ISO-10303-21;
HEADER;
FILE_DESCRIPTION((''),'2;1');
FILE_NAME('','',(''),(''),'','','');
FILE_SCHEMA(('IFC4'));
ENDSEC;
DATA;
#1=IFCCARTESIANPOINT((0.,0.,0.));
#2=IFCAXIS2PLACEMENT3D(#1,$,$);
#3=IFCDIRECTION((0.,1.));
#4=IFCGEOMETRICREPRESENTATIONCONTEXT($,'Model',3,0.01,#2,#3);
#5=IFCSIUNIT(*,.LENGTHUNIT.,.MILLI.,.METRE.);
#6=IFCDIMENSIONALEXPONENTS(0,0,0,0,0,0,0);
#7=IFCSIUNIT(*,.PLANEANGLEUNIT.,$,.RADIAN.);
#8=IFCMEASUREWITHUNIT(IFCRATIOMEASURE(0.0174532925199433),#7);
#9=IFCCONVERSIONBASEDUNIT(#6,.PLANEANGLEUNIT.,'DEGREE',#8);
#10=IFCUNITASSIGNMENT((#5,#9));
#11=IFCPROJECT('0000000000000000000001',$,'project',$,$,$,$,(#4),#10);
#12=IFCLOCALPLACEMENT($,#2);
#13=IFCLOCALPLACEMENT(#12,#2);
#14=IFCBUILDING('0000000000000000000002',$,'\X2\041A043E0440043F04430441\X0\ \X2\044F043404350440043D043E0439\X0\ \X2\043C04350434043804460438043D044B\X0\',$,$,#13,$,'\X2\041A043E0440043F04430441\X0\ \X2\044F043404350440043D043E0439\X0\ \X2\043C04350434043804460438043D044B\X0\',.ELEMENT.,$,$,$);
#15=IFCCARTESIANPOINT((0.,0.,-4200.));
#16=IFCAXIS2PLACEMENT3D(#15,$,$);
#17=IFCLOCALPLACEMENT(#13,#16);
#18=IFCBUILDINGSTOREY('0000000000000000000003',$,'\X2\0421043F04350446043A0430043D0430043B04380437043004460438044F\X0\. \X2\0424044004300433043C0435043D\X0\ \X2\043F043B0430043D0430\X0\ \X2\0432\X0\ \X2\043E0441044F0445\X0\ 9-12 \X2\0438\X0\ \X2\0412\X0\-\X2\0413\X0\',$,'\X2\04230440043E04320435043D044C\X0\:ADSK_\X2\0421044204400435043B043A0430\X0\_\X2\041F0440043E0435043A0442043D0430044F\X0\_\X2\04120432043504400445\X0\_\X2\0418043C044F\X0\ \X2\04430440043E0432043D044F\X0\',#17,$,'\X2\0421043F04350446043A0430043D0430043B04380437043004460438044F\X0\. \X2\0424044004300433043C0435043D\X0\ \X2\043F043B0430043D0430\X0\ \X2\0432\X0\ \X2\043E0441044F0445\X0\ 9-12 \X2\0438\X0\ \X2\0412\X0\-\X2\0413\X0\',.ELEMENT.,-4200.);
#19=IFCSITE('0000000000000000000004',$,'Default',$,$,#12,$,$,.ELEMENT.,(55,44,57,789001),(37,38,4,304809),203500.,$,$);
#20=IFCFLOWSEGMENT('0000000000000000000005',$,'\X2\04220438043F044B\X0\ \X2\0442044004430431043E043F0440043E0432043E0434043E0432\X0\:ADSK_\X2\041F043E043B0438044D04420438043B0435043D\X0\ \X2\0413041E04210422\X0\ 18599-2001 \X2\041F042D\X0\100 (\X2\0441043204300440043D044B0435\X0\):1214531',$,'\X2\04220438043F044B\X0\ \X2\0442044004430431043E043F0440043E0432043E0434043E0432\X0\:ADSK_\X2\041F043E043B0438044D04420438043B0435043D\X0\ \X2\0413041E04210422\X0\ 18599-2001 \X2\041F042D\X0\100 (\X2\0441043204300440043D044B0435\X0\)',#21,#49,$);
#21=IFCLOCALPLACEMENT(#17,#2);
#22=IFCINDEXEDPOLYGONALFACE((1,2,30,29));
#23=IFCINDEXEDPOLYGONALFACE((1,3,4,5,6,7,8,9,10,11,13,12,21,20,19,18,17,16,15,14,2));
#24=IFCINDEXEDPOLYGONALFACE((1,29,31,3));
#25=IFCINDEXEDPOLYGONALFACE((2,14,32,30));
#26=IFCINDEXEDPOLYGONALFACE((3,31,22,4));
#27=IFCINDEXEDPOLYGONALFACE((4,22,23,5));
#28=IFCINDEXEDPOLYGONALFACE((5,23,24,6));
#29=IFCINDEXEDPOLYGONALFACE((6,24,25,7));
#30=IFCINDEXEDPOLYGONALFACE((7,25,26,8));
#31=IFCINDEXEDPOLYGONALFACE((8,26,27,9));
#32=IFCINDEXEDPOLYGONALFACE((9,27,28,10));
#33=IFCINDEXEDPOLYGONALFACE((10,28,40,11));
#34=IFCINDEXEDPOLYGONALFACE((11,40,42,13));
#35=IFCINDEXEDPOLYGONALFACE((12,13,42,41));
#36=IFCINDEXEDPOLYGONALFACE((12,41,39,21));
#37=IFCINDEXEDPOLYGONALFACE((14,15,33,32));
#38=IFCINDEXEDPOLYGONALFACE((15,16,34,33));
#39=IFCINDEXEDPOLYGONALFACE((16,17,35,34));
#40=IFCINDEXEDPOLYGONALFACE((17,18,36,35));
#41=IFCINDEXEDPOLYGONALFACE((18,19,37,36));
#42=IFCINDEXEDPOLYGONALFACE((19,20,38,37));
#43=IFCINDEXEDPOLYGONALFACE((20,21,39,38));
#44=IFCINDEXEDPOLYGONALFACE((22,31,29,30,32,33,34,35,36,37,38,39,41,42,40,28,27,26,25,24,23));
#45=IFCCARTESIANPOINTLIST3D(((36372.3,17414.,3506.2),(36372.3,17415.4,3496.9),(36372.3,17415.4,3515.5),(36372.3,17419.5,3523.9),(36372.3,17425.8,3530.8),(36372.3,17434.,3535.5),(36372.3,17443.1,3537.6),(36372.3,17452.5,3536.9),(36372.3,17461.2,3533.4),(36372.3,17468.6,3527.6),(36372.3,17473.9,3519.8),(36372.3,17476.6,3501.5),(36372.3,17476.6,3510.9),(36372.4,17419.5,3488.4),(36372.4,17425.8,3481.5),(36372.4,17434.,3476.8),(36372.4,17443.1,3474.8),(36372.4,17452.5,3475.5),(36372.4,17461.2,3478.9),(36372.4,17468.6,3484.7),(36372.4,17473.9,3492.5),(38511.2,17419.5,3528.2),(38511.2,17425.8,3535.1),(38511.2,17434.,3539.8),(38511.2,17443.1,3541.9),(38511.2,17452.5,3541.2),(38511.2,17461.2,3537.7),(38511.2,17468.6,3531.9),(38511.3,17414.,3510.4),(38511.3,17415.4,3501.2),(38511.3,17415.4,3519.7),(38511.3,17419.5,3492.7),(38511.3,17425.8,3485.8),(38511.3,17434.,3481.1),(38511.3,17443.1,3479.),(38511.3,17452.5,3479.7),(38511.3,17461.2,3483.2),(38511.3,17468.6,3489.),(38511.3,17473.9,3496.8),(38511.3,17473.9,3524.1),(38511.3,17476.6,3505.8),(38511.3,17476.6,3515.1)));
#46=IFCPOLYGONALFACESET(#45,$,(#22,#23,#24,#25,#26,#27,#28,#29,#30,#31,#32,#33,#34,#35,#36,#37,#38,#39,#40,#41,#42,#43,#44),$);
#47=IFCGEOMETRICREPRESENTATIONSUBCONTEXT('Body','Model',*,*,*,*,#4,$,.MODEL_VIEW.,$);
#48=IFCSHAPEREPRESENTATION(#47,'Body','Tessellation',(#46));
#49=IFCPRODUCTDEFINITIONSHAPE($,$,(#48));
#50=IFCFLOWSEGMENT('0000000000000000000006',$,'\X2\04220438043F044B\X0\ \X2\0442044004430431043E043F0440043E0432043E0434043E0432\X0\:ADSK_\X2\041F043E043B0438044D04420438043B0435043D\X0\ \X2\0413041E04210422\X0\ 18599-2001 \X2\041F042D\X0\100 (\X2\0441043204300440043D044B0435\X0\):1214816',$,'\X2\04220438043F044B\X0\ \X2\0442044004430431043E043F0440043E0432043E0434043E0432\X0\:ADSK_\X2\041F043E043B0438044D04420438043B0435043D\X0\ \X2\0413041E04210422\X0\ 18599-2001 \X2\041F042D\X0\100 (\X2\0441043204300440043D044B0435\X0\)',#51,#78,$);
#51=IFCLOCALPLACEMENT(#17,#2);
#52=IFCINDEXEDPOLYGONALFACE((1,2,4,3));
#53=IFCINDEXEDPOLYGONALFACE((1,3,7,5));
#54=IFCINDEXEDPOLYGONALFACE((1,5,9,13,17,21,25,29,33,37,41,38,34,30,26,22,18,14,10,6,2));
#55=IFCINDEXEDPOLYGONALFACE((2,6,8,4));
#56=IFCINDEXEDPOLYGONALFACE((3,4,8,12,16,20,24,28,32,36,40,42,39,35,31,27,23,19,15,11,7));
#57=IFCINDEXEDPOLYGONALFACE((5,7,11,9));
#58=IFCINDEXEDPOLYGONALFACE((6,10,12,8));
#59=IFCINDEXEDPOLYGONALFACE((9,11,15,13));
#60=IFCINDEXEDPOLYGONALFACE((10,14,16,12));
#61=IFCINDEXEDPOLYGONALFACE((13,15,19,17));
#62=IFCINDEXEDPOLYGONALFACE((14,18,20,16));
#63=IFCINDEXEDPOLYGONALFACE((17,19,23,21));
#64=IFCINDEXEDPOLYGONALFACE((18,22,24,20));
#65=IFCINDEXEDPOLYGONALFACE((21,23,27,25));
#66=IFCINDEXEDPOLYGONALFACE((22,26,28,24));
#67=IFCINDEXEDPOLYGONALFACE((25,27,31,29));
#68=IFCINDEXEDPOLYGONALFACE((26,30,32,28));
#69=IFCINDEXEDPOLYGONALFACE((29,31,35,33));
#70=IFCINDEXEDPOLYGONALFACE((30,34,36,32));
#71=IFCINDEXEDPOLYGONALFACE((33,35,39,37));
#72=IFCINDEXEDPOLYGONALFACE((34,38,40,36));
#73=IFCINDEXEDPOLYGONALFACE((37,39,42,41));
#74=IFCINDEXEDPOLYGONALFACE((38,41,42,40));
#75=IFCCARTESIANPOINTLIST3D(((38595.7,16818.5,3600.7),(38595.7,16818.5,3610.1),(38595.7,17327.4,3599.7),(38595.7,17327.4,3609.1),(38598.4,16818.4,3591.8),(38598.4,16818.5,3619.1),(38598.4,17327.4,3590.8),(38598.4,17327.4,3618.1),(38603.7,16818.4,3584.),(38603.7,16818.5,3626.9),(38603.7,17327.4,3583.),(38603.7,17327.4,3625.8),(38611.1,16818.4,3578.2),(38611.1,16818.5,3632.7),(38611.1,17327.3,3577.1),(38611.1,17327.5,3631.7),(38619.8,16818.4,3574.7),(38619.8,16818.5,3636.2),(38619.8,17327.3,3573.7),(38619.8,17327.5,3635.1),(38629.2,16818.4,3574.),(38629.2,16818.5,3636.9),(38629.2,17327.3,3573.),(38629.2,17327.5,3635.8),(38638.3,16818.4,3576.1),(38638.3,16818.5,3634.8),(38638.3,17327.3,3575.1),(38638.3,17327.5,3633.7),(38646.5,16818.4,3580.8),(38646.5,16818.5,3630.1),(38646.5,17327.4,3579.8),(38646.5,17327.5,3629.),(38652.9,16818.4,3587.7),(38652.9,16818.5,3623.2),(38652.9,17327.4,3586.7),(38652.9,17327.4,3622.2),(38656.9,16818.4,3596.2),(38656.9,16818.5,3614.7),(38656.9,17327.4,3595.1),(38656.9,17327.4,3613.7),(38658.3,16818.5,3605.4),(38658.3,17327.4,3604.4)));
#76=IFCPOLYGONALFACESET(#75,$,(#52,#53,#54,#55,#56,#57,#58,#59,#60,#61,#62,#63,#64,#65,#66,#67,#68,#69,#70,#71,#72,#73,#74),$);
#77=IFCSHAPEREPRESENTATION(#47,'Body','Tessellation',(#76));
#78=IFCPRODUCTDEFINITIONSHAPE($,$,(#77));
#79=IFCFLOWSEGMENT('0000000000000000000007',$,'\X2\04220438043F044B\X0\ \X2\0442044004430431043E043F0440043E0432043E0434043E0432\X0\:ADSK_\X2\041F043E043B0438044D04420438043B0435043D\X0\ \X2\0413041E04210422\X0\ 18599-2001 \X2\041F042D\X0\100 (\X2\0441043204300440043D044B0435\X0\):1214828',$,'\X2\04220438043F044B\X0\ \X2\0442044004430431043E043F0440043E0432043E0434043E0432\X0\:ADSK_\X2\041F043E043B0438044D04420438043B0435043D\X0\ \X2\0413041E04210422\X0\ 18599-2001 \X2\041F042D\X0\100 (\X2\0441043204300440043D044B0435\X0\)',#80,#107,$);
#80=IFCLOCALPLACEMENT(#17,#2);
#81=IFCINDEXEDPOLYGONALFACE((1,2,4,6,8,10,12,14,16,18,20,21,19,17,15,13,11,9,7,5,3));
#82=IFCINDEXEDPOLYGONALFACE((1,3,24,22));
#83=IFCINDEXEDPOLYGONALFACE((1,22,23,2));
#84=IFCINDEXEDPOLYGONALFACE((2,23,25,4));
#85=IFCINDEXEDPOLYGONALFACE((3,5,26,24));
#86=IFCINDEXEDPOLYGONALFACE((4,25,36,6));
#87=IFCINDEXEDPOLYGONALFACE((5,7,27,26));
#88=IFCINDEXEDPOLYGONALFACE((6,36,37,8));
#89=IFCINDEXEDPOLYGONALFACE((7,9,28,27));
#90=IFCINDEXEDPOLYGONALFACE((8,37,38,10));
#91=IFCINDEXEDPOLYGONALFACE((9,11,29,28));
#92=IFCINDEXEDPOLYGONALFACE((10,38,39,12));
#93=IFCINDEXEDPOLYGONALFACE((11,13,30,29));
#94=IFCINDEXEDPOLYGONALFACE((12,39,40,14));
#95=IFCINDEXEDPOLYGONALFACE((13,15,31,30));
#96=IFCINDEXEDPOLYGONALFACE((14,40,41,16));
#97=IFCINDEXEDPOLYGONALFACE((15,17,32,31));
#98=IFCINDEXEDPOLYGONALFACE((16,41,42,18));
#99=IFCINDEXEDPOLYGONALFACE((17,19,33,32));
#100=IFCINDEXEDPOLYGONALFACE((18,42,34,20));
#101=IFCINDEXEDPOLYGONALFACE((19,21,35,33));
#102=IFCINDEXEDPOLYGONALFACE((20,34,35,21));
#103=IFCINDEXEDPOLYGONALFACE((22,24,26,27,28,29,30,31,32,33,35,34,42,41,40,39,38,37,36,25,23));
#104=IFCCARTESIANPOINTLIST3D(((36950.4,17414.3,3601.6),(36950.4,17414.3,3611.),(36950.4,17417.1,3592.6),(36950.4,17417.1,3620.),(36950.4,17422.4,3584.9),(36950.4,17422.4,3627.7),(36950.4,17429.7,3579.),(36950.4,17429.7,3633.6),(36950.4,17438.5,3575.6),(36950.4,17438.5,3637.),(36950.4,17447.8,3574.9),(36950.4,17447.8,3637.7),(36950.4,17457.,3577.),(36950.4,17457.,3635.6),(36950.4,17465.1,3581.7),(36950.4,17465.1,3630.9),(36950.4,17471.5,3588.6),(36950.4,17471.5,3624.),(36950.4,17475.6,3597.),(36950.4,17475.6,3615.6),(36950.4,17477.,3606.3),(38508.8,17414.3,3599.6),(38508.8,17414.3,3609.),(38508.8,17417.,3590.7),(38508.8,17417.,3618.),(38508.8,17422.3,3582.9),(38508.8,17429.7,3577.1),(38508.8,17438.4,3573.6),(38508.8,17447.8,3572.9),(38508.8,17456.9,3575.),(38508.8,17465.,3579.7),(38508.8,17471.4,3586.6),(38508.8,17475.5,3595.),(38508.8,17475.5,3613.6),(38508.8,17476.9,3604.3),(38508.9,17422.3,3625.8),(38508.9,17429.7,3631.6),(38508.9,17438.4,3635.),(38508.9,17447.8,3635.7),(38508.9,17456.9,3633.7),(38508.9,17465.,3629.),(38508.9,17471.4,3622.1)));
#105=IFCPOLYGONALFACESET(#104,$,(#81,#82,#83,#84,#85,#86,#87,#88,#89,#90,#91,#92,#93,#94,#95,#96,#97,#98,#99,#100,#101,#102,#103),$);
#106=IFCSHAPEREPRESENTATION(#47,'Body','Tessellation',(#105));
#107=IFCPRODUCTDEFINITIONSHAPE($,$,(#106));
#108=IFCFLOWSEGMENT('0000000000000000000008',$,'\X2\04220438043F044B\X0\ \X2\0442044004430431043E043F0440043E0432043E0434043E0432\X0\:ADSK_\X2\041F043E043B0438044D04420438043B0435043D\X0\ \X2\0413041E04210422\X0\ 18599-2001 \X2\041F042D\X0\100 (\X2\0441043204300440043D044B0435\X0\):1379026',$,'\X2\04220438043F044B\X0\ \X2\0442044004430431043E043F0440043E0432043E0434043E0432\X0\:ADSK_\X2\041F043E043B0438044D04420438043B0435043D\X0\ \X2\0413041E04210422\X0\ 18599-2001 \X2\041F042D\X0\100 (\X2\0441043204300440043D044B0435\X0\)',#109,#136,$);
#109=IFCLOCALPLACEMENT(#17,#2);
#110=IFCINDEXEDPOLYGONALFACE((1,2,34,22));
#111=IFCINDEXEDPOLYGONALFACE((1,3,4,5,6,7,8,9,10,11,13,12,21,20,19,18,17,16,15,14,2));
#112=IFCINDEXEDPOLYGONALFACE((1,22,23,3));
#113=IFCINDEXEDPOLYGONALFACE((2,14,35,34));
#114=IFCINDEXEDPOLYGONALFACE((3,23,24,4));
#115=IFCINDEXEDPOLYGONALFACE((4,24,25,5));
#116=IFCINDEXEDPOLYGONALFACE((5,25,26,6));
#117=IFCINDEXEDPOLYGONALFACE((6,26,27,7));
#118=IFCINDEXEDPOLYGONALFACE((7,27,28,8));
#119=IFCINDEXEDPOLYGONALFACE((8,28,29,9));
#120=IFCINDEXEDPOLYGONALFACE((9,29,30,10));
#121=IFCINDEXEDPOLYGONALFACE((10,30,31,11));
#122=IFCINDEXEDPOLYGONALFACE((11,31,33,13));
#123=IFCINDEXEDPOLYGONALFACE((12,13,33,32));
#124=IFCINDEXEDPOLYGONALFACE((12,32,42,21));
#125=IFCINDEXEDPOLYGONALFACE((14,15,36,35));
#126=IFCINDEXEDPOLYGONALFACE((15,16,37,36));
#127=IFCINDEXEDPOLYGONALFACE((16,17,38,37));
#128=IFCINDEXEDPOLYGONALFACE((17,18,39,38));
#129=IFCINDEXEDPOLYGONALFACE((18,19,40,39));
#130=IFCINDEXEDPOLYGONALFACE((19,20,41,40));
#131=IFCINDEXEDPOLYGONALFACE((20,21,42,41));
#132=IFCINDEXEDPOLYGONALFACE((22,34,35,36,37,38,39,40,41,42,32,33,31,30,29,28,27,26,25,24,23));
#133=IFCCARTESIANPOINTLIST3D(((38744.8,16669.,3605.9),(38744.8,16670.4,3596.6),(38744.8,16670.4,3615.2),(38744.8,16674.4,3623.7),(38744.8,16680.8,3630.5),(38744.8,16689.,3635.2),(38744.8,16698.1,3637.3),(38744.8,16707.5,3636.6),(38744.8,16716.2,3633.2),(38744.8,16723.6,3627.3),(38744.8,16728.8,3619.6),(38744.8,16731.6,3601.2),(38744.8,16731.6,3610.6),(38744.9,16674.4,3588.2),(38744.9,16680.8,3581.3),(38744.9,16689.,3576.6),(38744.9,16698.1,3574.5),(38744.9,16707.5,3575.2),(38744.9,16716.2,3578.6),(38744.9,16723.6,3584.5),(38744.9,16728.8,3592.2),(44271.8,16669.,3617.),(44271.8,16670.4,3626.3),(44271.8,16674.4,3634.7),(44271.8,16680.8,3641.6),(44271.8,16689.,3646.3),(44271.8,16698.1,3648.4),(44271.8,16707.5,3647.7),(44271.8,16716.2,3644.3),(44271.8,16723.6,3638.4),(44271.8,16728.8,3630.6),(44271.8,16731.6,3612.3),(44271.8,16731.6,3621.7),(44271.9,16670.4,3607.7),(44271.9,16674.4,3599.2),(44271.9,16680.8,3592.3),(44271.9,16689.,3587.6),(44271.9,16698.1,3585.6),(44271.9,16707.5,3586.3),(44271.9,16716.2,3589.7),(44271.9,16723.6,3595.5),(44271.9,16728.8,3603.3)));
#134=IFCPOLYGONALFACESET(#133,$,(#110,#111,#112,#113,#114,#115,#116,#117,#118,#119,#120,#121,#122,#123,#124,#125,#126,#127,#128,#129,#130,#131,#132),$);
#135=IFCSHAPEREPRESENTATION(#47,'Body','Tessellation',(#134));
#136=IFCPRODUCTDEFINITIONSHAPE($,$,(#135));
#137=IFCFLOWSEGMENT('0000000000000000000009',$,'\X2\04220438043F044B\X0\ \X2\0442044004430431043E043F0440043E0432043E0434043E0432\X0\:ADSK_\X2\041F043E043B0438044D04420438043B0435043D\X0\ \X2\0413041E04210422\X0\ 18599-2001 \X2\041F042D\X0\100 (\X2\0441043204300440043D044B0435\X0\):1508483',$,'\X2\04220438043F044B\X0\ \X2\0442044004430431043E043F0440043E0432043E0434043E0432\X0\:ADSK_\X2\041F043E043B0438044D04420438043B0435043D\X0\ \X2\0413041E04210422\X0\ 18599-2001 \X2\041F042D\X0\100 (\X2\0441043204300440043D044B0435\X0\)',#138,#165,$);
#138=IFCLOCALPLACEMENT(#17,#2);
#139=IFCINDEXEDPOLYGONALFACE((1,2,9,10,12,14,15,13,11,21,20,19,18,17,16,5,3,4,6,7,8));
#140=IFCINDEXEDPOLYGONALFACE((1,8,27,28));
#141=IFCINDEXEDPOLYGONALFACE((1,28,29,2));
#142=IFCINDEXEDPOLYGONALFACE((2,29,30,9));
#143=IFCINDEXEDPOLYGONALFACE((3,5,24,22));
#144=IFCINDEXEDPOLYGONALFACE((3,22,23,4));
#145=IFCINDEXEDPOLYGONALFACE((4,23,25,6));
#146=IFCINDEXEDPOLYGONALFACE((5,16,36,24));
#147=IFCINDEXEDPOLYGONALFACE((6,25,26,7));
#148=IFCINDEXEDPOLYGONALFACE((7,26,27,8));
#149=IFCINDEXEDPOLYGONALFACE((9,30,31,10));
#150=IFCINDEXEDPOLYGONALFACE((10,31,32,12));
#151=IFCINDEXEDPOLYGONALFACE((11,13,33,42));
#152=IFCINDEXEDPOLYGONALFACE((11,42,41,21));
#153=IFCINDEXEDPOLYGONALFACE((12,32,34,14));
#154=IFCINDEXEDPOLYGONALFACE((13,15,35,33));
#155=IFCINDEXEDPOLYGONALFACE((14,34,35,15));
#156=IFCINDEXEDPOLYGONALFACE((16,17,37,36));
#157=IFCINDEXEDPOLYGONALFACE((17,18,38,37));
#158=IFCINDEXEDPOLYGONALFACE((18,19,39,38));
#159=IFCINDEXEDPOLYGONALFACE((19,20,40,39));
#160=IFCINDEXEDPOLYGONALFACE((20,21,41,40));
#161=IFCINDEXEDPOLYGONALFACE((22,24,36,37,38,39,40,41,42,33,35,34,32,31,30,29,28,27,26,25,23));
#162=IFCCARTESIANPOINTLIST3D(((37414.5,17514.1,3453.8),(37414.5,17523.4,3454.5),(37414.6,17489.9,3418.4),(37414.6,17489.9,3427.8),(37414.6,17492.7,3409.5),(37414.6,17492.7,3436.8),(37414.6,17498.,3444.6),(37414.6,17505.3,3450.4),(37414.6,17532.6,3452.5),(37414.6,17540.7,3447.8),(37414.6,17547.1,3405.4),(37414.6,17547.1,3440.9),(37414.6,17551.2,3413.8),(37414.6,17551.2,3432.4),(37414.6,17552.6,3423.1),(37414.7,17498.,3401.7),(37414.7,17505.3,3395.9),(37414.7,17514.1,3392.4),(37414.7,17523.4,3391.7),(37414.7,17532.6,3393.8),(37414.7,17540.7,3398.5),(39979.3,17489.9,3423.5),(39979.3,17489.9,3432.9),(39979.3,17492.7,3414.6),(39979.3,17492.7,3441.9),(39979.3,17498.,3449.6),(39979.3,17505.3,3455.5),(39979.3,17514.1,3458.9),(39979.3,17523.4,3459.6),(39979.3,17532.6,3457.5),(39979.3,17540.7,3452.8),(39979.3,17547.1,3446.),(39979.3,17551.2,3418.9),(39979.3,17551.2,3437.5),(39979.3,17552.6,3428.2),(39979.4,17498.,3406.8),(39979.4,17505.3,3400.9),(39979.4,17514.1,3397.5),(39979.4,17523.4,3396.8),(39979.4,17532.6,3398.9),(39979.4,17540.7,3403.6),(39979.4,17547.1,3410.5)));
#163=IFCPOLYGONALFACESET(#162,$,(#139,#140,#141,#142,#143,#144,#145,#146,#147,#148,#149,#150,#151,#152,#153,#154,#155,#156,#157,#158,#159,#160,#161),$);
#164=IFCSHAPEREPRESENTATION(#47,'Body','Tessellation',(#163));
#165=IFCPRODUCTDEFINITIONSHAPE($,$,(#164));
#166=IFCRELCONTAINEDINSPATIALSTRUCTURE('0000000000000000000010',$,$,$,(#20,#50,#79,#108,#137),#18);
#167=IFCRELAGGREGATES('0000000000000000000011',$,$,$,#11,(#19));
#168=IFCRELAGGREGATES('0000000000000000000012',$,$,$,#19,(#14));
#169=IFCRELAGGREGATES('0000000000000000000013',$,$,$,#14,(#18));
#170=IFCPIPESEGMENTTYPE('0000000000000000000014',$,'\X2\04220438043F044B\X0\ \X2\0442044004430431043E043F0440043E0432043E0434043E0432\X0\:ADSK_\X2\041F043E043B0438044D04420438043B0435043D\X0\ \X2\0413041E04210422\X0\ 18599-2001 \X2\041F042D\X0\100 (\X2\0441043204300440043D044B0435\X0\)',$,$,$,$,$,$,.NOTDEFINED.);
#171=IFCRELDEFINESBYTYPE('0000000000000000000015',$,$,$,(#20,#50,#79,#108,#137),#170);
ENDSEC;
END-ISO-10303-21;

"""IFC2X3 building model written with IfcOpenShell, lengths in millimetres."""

from ifc_helpers import new_model, entity, si_unit, converted_unit, direction, frame, frame_2d, origin, origin_2d_with_axis, place, context, subcontext, project, spatial, circle, extrude, type_object, element, save


model = new_model("IFC2X3")

# Units and contexts
model_context = context("Model", 3, precision=0.01, world=origin(), true_north=direction((0.0, 1.0)))
body_context = subcontext(model_context, "Body", "Model", "MODEL_VIEW")
ifc_project = project(units=[si_unit("LENGTHUNIT", "METRE", prefix="MILLI"), converted_unit("PLANEANGLEUNIT", "DEGREE", entity("IfcRatioMeasure", 0.0174532925199433), si_unit("PLANEANGLEUNIT", "RADIAN"), dimensions=[0, 0, 0, 0, 0, 0, 0])], contexts=[model_context])

# Site, building, storey
site_placement = place(None, frame((0.0, 0.0, 0.0)))
site = spatial("IfcSite", under=ifc_project, at=site_placement, Name="Default", CompositionType="ELEMENT", RefLatitude=(55, 44, 57, 789001), RefLongitude=(37, 38, 4, 304809), RefElevation=203500.0)
building_placement = place(site_placement, origin())
building = spatial("IfcBuilding", under=site, at=building_placement, Name="Корпус ядерной медицины", LongName="Корпус ядерной медицины", CompositionType="ELEMENT")
storey_placement = place(building_placement, frame((0.0, 0.0, -4200.0)))
storey = spatial("IfcBuildingStorey", under=building, at=storey_placement, Name="Спецканализация. Фрагмен плана в осях 9-12 и В-Г", ObjectType="Уровень:ADSK_Стрелка_Проектная_Вверх_Имя уровня", LongName="Спецканализация. Фрагмен плана в осях 9-12 и В-Г", CompositionType="ELEMENT", Elevation=-4200.0)

# Flow segments
pipe_segment_type = type_object("IfcPipeSegmentType", Name="Типы трубопроводов:ADSK_Полиэтилен ГОСТ 18599-2001 ПЭ100 (сварные)", PredefinedType="NOTDEFINED")
flow_segment_1_placement = place(storey_placement, frame((36372.3, 17412.4, 3473.1)))
element("IfcFlowSegment", 1, at=flow_segment_1_placement, inside=storey, type_object=pipe_segment_type, Name="Типы трубопроводов:ADSK_Полиэтилен ГОСТ 18599-2001 ПЭ100 (сварные):1214531", ObjectType="Типы трубопроводов:ADSK_Полиэтилен ГОСТ 18599-2001 ПЭ100 (сварные)", context=body_context, shape_type="SweptSolid", body=[
    extrude(circle(Radius=31.5, at=frame_2d((0.0, 0.0), x_axis=(1.0, 0.0))), frame((0.1, 33.1, 33.1), z_axis=(0.999998, 0.0, 0.002), x_axis=(0.0, -1.0, 0.0)), (0.0, 0.0, 1.0), 2139.0),
])
flow_segment_2_placement = place(storey_placement, frame((38593.7, 16818.4, 3571.3)))
element("IfcFlowSegment", 2, at=flow_segment_2_placement, inside=storey, type_object=pipe_segment_type, Name="Типы трубопроводов:ADSK_Полиэтилен ГОСТ 18599-2001 ПЭ100 (сварные):1214816", ObjectType="Типы трубопроводов:ADSK_Полиэтилен ГОСТ 18599-2001 ПЭ100 (сварные)", context=body_context, shape_type="SweptSolid", body=[
    extrude(circle(Radius=31.5, at=origin_2d_with_axis()), frame((33.1, 509.0, 33.1), z_axis=(0.0, -0.999998, 0.002007), x_axis=(1.0, 0.0, 0.0)), (0.0, 0.0, 1.0), 508.9),
])
flow_segment_3_placement = place(storey_placement, frame((36950.4, 17412.3, 3571.2)))
element("IfcFlowSegment", 3, at=flow_segment_3_placement, inside=storey, type_object=pipe_segment_type, Name="Типы трубопроводов:ADSK_Полиэтилен ГОСТ 18599-2001 ПЭ100 (сварные):1214828", ObjectType="Типы трубопроводов:ADSK_Полиэтилен ГОСТ 18599-2001 ПЭ100 (сварные)", context=body_context, shape_type="SweptSolid", body=[
    extrude(circle(Radius=31.5, at=frame_2d((0.0, 0.0), x_axis=(1.0, 0.0))), frame((1558.5, 33.1, 33.1), z_axis=(-0.999999, 0.000046, 0.001263), x_axis=(0.000046, 1.0, 0.0)), (0.0, 0.0, 1.0), 1558.4),
])
flow_segment_4_placement = place(storey_placement, frame((38744.8, 16667.4, 3572.8)))
element("IfcFlowSegment", 4, at=flow_segment_4_placement, inside=storey, type_object=pipe_segment_type, Name="Типы трубопроводов:ADSK_Полиэтилен ГОСТ 18599-2001 ПЭ100 (сварные):1379026", ObjectType="Типы трубопроводов:ADSK_Полиэтилен ГОСТ 18599-2001 ПЭ100 (сварные)", context=body_context, shape_type="SweptSolid", body=[
    extrude(circle(Radius=31.5, at=frame_2d((0.0, 0.0), x_axis=(1.0, 0.0))), frame((0.1, 33.1, 33.1), z_axis=(0.999998, 0.0, 0.002001), x_axis=(0.0, -1.0, 0.0)), (0.0, 0.0, 1.0), 5527.0),
])
flow_segment_5_placement = place(storey_placement, frame((37414.5, 17488.0, 3390.0)))
element("IfcFlowSegment", 5, at=flow_segment_5_placement, inside=storey, type_object=pipe_segment_type, Name="Типы трубопроводов:ADSK_Полиэтилен ГОСТ 18599-2001 ПЭ100 (сварные):1508483", ObjectType="Типы трубопроводов:ADSK_Полиэтилен ГОСТ 18599-2001 ПЭ100 (сварные)", context=body_context, shape_type="SweptSolid", body=[
    extrude(circle(Radius=31.5, at=origin_2d_with_axis()), frame((0.1, 33.1, 33.1), z_axis=(0.999998, 0.0, 0.001985), x_axis=(0.0, 1.0, 0.0)), (0.0, 0.0, 1.0), 2564.7),
])

save(model, "model.ifc")
